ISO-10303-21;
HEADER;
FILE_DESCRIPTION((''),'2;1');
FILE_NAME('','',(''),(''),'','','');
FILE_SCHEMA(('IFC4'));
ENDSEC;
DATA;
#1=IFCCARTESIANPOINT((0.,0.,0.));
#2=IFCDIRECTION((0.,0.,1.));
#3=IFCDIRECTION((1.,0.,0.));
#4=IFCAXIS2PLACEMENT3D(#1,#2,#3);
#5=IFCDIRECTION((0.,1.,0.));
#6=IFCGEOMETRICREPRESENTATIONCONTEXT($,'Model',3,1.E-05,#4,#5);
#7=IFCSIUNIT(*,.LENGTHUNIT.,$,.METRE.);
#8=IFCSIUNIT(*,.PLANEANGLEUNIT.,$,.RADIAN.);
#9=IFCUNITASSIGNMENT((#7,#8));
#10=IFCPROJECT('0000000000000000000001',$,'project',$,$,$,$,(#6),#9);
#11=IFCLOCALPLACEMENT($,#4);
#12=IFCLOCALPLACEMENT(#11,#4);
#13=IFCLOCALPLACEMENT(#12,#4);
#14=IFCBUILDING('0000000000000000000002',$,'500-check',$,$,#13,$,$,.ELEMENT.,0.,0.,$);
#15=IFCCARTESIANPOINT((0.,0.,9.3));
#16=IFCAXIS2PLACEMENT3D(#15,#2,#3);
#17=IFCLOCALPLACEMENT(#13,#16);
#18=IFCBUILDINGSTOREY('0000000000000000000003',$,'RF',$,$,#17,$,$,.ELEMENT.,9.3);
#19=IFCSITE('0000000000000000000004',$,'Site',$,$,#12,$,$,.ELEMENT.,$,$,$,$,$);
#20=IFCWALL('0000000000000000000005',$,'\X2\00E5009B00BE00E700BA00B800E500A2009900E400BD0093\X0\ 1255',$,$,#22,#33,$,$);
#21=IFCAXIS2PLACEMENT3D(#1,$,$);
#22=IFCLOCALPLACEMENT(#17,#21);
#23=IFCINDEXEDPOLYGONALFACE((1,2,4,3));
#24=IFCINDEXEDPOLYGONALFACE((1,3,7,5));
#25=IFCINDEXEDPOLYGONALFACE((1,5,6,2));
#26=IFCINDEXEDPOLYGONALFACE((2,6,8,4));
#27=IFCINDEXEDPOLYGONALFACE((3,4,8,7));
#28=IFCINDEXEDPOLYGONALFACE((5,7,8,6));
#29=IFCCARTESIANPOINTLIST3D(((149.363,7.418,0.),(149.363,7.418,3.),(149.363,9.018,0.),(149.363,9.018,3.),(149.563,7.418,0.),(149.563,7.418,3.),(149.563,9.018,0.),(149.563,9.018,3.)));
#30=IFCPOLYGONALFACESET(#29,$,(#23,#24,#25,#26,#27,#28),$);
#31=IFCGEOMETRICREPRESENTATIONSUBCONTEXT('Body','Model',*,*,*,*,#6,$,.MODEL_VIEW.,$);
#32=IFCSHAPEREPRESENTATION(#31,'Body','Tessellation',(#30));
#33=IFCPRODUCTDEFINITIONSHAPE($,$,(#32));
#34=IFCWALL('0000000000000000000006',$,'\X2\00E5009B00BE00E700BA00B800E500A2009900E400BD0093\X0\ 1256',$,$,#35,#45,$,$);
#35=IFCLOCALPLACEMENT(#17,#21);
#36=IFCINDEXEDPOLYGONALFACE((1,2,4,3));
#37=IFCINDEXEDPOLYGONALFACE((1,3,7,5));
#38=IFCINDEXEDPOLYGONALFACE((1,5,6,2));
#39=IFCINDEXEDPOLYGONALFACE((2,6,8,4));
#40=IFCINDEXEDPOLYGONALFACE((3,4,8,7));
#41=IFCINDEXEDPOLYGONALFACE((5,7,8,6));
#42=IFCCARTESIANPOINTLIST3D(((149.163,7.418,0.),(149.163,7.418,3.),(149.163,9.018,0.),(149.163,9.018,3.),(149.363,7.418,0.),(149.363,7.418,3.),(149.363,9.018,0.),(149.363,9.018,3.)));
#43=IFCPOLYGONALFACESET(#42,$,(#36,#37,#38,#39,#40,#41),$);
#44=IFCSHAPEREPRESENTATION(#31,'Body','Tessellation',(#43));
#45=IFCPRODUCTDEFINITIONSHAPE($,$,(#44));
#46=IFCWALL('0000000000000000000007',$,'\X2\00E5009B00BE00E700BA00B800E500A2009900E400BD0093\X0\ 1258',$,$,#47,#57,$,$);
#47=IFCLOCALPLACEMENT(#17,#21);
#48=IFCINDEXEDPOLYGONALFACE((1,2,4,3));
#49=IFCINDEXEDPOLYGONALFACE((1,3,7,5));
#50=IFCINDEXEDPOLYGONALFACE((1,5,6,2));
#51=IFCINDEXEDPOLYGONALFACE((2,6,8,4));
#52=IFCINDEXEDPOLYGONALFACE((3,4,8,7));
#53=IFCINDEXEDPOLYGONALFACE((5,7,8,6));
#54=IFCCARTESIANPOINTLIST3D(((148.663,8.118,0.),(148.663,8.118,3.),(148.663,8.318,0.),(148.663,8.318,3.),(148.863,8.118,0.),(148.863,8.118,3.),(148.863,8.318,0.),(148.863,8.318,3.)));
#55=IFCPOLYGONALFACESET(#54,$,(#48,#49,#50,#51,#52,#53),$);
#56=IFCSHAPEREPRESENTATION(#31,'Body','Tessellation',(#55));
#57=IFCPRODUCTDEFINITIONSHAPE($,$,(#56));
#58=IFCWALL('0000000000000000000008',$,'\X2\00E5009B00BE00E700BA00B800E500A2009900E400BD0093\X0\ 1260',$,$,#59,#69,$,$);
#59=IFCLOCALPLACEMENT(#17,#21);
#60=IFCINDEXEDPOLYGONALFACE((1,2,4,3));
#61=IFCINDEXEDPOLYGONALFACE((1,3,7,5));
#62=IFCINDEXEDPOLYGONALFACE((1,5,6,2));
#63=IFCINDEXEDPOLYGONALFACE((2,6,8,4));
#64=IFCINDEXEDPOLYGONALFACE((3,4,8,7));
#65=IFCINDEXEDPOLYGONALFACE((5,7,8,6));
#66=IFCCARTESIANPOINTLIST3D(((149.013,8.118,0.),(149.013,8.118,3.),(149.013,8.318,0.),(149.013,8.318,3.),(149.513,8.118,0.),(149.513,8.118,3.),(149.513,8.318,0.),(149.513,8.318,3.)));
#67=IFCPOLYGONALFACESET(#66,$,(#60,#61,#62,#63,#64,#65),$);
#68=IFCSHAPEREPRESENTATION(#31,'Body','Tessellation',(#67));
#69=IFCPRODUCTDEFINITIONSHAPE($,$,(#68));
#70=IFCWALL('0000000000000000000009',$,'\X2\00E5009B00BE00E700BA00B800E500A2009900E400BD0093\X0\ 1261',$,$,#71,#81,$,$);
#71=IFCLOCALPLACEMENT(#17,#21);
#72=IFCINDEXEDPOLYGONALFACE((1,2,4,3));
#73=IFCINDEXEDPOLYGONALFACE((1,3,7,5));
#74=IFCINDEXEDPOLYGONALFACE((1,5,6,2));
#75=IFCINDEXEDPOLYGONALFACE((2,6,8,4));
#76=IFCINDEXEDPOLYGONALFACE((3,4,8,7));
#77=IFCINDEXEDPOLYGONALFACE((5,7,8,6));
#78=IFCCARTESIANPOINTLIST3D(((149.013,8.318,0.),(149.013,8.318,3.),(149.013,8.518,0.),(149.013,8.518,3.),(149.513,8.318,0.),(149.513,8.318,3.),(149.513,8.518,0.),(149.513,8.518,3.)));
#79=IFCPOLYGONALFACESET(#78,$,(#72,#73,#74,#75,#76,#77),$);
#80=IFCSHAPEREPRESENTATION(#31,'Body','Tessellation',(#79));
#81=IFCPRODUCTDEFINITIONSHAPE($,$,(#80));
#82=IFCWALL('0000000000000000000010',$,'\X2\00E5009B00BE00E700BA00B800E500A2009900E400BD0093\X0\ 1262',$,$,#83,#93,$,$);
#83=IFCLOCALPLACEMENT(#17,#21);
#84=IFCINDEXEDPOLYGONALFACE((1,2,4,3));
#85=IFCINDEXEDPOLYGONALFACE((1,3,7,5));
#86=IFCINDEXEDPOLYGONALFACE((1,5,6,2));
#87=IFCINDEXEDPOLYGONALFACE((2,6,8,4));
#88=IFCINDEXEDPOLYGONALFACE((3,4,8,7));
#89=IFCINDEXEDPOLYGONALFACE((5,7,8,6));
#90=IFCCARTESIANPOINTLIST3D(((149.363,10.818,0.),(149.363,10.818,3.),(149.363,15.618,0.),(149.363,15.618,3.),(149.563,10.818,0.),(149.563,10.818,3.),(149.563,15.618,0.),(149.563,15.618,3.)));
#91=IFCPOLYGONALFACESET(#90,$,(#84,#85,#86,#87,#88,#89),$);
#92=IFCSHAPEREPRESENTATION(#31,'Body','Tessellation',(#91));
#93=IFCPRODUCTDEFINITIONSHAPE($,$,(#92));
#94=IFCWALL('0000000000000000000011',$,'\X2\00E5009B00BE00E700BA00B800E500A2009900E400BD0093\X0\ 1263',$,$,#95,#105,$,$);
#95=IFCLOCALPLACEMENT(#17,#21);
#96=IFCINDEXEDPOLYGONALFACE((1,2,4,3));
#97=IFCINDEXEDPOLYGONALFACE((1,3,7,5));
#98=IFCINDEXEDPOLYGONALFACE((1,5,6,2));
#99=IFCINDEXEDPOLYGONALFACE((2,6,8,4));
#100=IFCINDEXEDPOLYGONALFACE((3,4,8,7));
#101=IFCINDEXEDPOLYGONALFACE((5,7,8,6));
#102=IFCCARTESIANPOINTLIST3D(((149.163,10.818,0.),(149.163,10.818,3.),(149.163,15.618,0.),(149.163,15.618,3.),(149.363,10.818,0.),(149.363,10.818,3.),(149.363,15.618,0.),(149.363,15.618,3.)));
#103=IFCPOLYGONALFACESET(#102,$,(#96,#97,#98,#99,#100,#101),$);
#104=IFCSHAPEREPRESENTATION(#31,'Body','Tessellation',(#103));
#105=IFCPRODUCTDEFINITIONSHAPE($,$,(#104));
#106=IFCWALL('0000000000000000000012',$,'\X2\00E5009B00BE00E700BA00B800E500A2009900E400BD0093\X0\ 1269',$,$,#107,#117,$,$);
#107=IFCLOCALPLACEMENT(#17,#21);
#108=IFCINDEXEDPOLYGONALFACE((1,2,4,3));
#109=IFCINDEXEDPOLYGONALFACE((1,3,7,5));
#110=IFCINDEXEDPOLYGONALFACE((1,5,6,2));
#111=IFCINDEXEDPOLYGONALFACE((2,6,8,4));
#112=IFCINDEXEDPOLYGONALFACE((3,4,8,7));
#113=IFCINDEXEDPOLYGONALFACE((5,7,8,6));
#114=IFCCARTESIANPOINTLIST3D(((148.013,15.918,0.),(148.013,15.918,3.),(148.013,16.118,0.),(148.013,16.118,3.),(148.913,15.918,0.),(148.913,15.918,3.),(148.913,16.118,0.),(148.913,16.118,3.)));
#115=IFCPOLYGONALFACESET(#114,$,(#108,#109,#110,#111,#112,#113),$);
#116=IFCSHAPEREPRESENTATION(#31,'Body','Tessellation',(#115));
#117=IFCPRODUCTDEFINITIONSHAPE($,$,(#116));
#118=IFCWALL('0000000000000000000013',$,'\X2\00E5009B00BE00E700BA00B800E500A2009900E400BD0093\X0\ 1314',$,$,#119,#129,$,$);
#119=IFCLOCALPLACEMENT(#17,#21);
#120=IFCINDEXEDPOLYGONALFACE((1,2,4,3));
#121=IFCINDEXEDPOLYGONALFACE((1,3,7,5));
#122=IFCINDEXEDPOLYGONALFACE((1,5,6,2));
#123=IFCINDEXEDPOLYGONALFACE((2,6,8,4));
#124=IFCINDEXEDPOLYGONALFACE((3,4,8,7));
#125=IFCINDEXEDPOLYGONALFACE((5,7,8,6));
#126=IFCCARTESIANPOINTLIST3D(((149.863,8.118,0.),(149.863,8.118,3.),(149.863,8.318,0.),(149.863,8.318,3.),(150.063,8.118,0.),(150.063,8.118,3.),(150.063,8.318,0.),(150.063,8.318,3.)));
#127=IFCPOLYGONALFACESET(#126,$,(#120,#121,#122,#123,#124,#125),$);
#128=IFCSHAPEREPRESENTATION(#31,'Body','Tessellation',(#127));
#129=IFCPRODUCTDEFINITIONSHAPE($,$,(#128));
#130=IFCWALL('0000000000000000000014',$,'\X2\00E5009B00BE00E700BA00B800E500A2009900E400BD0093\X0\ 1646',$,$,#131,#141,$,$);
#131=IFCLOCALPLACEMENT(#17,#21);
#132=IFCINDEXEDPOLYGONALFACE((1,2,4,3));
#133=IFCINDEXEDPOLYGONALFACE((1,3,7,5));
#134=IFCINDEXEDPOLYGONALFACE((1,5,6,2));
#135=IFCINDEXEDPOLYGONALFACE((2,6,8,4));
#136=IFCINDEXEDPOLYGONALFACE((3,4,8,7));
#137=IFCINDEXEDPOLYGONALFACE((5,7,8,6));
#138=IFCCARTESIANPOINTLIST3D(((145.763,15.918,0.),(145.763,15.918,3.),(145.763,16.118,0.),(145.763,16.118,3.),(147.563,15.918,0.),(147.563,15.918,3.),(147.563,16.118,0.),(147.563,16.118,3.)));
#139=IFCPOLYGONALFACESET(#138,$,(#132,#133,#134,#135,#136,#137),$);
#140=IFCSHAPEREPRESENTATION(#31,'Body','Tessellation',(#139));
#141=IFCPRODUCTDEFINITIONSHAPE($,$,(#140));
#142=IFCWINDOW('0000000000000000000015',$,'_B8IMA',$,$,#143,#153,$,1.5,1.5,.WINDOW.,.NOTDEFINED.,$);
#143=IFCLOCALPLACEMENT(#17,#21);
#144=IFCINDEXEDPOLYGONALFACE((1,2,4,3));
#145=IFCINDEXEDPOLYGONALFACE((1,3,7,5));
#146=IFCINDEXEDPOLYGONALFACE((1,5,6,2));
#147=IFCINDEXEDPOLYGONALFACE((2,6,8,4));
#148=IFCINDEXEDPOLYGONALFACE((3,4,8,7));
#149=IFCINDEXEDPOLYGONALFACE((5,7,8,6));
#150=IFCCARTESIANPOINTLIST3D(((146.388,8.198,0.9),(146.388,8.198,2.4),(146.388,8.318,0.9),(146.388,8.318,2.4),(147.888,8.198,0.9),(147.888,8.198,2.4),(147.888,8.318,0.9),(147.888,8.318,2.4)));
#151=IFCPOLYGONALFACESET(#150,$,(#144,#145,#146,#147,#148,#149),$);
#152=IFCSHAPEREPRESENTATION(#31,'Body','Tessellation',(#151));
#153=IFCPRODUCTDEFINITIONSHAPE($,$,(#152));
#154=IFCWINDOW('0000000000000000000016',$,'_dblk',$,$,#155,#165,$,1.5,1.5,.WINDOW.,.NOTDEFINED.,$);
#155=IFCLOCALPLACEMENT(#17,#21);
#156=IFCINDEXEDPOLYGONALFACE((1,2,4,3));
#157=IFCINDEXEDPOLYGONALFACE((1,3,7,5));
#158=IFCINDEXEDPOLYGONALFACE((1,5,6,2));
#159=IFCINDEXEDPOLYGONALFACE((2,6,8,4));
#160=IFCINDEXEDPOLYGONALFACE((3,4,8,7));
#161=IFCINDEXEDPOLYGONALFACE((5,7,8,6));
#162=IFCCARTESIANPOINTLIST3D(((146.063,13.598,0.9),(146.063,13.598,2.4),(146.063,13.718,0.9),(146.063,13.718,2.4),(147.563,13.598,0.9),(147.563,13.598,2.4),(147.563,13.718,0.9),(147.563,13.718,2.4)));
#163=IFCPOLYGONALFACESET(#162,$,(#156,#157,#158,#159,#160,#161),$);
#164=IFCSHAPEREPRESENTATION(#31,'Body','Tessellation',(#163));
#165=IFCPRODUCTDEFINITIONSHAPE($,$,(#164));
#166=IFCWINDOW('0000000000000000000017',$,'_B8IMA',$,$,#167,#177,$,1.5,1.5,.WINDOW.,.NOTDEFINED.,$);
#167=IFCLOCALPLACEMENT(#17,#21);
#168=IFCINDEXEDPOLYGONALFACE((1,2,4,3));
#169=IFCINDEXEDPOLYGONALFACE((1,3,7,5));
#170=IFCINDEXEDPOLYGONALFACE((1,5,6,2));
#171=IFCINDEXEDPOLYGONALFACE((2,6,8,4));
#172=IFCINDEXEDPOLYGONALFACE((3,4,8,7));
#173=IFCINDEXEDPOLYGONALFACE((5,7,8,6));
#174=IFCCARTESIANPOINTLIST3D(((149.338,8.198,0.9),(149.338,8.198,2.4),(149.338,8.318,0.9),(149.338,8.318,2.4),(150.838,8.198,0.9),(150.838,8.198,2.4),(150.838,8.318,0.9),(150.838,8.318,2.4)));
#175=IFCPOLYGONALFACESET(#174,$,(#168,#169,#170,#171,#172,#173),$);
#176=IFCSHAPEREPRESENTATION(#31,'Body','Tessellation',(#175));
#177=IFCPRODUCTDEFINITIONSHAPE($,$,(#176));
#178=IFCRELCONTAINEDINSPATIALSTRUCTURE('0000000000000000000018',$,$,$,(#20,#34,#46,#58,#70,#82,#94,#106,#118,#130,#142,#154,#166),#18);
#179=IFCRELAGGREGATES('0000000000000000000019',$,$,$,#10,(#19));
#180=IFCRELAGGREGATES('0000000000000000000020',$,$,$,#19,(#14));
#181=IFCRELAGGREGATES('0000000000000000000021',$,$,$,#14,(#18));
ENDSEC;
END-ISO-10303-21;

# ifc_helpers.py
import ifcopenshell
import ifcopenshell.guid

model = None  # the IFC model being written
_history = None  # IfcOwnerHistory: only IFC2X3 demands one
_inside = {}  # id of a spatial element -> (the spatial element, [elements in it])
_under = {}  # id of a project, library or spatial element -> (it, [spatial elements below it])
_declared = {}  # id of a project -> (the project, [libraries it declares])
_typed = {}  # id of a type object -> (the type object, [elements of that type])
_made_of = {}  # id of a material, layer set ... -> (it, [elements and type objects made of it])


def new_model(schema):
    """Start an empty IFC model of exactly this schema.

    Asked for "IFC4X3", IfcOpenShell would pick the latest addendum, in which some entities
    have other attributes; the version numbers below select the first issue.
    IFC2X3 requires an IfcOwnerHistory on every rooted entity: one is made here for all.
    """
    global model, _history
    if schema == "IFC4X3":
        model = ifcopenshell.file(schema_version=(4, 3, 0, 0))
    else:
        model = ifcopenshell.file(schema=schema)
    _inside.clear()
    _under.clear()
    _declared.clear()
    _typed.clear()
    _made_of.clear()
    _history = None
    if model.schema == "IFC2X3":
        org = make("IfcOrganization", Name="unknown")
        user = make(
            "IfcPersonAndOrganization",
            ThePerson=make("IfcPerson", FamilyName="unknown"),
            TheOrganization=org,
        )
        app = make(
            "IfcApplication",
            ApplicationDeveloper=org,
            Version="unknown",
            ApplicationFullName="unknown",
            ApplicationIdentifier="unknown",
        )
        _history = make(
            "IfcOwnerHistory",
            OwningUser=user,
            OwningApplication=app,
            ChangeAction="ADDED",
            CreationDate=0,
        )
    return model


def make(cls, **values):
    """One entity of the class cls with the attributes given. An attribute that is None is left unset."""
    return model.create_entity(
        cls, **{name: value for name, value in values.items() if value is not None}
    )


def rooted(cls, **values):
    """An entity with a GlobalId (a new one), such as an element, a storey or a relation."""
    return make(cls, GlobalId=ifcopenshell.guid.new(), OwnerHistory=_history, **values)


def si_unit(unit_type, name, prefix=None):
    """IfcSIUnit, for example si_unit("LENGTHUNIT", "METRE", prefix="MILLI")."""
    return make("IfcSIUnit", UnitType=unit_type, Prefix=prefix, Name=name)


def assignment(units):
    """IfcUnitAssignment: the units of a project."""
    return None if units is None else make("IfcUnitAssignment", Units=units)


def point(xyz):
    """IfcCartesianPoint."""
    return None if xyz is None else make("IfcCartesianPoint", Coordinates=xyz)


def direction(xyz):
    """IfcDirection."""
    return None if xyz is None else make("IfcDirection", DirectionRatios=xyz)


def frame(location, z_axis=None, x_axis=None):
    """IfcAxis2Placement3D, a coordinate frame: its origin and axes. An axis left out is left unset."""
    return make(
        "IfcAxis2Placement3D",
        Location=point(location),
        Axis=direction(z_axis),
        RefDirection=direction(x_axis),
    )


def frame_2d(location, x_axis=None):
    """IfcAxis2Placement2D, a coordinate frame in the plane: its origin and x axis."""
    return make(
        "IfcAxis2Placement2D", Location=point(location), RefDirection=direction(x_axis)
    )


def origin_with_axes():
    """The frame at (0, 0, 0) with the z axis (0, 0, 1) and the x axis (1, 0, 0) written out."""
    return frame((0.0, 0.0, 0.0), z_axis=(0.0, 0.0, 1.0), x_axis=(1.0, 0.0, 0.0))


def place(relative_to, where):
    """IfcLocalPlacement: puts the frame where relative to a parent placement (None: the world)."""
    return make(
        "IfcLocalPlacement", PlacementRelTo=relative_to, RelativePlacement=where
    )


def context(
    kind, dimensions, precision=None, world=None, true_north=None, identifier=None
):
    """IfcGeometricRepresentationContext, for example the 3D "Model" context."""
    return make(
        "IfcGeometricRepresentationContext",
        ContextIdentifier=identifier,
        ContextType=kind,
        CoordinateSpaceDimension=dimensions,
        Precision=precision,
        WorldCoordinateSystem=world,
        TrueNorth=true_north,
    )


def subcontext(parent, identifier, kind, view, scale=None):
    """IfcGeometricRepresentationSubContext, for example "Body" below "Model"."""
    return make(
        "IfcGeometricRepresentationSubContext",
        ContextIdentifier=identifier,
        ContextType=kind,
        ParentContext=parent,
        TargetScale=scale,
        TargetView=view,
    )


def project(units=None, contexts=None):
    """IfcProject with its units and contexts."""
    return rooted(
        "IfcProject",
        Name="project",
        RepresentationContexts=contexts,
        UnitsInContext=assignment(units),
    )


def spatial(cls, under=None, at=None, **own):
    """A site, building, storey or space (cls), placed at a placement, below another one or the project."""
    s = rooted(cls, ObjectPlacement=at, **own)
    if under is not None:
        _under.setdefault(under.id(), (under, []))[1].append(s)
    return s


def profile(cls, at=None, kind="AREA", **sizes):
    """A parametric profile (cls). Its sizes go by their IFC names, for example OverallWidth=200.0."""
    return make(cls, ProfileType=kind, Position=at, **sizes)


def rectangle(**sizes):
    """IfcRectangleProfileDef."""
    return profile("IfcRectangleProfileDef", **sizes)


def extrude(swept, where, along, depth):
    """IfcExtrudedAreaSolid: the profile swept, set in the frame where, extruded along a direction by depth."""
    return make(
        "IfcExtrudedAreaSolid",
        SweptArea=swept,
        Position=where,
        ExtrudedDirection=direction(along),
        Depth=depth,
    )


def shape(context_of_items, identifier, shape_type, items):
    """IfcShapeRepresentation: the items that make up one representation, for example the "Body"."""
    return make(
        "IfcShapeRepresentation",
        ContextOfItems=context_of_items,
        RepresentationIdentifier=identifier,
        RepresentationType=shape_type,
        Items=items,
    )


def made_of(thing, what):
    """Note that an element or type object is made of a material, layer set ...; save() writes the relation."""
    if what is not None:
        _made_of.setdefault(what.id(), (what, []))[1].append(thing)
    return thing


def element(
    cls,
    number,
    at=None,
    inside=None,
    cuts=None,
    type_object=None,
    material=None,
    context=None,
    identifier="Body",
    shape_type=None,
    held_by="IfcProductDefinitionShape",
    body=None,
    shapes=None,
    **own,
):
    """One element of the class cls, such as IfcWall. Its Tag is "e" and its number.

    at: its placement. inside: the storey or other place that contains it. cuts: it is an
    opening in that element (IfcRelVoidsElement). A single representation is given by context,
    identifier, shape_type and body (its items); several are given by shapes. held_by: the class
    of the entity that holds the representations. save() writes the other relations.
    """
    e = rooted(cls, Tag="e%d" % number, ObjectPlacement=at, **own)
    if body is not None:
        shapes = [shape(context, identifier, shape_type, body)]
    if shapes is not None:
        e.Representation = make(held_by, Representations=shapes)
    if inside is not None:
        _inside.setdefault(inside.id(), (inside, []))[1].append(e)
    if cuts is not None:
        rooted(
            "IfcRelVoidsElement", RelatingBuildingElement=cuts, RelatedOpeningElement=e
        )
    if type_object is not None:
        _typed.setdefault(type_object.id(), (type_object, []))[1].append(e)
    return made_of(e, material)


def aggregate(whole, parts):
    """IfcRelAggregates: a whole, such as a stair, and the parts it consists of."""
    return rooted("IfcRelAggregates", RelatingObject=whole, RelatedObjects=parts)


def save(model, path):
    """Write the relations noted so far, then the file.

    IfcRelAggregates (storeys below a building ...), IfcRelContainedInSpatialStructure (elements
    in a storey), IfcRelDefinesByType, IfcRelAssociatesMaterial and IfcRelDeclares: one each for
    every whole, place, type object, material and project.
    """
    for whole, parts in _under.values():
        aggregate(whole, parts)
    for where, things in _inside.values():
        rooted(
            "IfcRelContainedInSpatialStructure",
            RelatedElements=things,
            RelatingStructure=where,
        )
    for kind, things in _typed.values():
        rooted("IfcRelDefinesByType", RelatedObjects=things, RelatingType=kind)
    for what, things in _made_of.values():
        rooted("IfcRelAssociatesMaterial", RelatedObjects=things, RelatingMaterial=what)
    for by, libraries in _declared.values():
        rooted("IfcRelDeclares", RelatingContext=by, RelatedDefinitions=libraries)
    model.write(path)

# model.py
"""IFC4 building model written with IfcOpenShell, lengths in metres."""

from ifc_helpers import new_model, si_unit, direction, frame, frame_2d, origin_with_axes, place, context, subcontext, project, spatial, rectangle, extrude, element, save


model = new_model("IFC4")

# Units and contexts
model_context = context("Model", 3, precision=1e-05, world=origin_with_axes(), true_north=direction((0.0, 1.0, 0.0)))
body_context = subcontext(model_context, "Body", "Model", "MODEL_VIEW")
ifc_project = project(units=[si_unit("LENGTHUNIT", "METRE"), si_unit("PLANEANGLEUNIT", "RADIAN")], contexts=[model_context])

# Site, building, storey
placement = place(None, origin_with_axes())
site_placement = place(placement, origin_with_axes())
site = spatial("IfcSite", under=ifc_project, at=site_placement, Name="Site", CompositionType="ELEMENT")
building_placement = place(site_placement, origin_with_axes())
building = spatial("IfcBuilding", under=site, at=building_placement, Name="500-check", CompositionType="ELEMENT", ElevationOfRefHeight=0.0, ElevationOfTerrain=0.0)
storey_placement = place(building_placement, frame((0.0, 0.0, 9.3), z_axis=(0.0, 0.0, 1.0), x_axis=(1.0, 0.0, 0.0)))
storey = spatial("IfcBuildingStorey", under=building, at=storey_placement, Name="RF", CompositionType="ELEMENT", Elevation=9.3)

# Walls
for number, where, z_axis, x_axis, name in (
    (1, (149.463, 8.218, 0.0), (0.0, 0.0, 1.0), (0.0, -1.0, 0.0), "å\u009b¾çº¸å¢\u0099ä½\u0093 1255"),
    (2, (149.263, 8.218, 0.0), (0.0, 0.0, 1.0), (0.0, -1.0, 0.0), "å\u009b¾çº¸å¢\u0099ä½\u0093 1256"),
):
    element("IfcWall", number, at=place(storey_placement, frame(where, z_axis=z_axis, x_axis=x_axis)), inside=storey, Name=name, context=body_context, shape_type="SweptSolid", body=[
        extrude(rectangle(XDim=1.6, YDim=0.2, at=frame_2d((0.0, 0.0), x_axis=(1.0, 0.0, 0.0))), frame((0.0, 0.0, 0.0), z_axis=(0.0, 0.0, 1.0)), (0.0, 0.0, 1.0), 3.0),
    ])
wall_1_placement = place(storey_placement, frame((148.763, 8.218, 0.0), z_axis=(0.0, 0.0, 1.0), x_axis=(0.0, 1.0, 0.0)))
element("IfcWall", 3, at=wall_1_placement, inside=storey, Name="å\u009b¾çº¸å¢\u0099ä½\u0093 1258", context=body_context, shape_type="SweptSolid", body=[
    extrude(rectangle(XDim=0.2, YDim=0.2, at=frame_2d((0.0, 0.0), x_axis=(1.0, 0.0, 0.0))), frame((0.0, 0.0, 0.0), z_axis=(0.0, 0.0, 1.0)), (0.0, 0.0, 1.0), 3.0),
])
for number, where, z_axis, x_axis, name in (
    (4, (149.263, 8.218, 0.0), (0.0, 0.0, 1.0), (-1.0, 0.0, 0.0), "å\u009b¾çº¸å¢\u0099ä½\u0093 1260"),
    (5, (149.263, 8.418, 0.0), (0.0, 0.0, 1.0), (-1.0, 0.0, 0.0), "å\u009b¾çº¸å¢\u0099ä½\u0093 1261"),
):
    element("IfcWall", number, at=place(storey_placement, frame(where, z_axis=z_axis, x_axis=x_axis)), inside=storey, Name=name, context=body_context, shape_type="SweptSolid", body=[
        extrude(rectangle(XDim=0.5, YDim=0.2, at=frame_2d((0.0, 0.0), x_axis=(1.0, 0.0, 0.0))), frame((0.0, 0.0, 0.0), z_axis=(0.0, 0.0, 1.0)), (0.0, 0.0, 1.0), 3.0),
    ])
for number, where, z_axis, x_axis, name in (
    (6, (149.463, 13.218, 0.0), (0.0, 0.0, 1.0), (0.0, -1.0, 0.0), "å\u009b¾çº¸å¢\u0099ä½\u0093 1262"),
    (7, (149.263, 13.218, 0.0), (0.0, 0.0, 1.0), (0.0, -1.0, 0.0), "å\u009b¾çº¸å¢\u0099ä½\u0093 1263"),
):
    element("IfcWall", number, at=place(storey_placement, frame(where, z_axis=z_axis, x_axis=x_axis)), inside=storey, Name=name, context=body_context, shape_type="SweptSolid", body=[
        extrude(rectangle(XDim=4.8, YDim=0.2, at=frame_2d((0.0, 0.0), x_axis=(1.0, 0.0, 0.0))), frame((0.0, 0.0, 0.0), z_axis=(0.0, 0.0, 1.0)), (0.0, 0.0, 1.0), 3.0),
    ])
wall_2_placement = place(storey_placement, frame((148.463, 16.018, 0.0), z_axis=(0.0, 0.0, 1.0), x_axis=(1.0, 0.0, 0.0)))
element("IfcWall", 8, at=wall_2_placement, inside=storey, Name="å\u009b¾çº¸å¢\u0099ä½\u0093 1269", context=body_context, shape_type="SweptSolid", body=[
    extrude(rectangle(XDim=0.9, YDim=0.2, at=frame_2d((0.0, 0.0), x_axis=(1.0, 0.0, 0.0))), frame((0.0, 0.0, 0.0), z_axis=(0.0, 0.0, 1.0)), (0.0, 0.0, 1.0), 3.0),
])
wall_3_placement = place(storey_placement, frame((149.963, 8.218, 0.0), z_axis=(0.0, 0.0, 1.0), x_axis=(0.0, 1.0, 0.0)))
element("IfcWall", 9, at=wall_3_placement, inside=storey, Name="å\u009b¾çº¸å¢\u0099ä½\u0093 1314", context=body_context, shape_type="SweptSolid", body=[
    extrude(rectangle(XDim=0.2, YDim=0.2, at=frame_2d((0.0, 0.0), x_axis=(1.0, 0.0, 0.0))), frame((0.0, 0.0, 0.0), z_axis=(0.0, 0.0, 1.0)), (0.0, 0.0, 1.0), 3.0),
])
wall_4_placement = place(storey_placement, frame((146.663, 16.018, 0.0), z_axis=(0.0, 0.0, 1.0), x_axis=(1.0, 0.0, 0.0)))
element("IfcWall", 10, at=wall_4_placement, inside=storey, Name="å\u009b¾çº¸å¢\u0099ä½\u0093 1646", context=body_context, shape_type="SweptSolid", body=[
    extrude(rectangle(XDim=1.8, YDim=0.2, at=frame_2d((0.0, 0.0), x_axis=(1.0, 0.0, 0.0))), frame((0.0, 0.0, 0.0), z_axis=(0.0, 0.0, 1.0)), (0.0, 0.0, 1.0), 3.0),
])

# Windows
for number, where, z_axis, x_axis, name in (
    (11, (147.138, 8.258, 0.9), (0.0, 0.0, 1.0), (1.0, 0.0, 0.0), "_B8IMA"),
    (12, (146.813, 13.658, 0.9), (0.0, 0.0, 1.0), (1.0, 0.0, 0.0), "_dblk"),
    (13, (150.088, 8.258, 0.9), (0.0, 0.0, 1.0), (1.0, 0.0, 0.0), "_B8IMA"),
):
    element("IfcWindow", number, at=place(storey_placement, frame(where, z_axis=z_axis, x_axis=x_axis)), inside=storey, Name=name, OverallHeight=1.5, OverallWidth=1.5, PartitioningType="NOTDEFINED", PredefinedType="WINDOW", context=body_context, shape_type="SweptSolid", body=[
        extrude(rectangle(XDim=1.5, YDim=0.12, at=frame_2d((0.0, 0.0), x_axis=(1.0, 0.0, 0.0))), frame((0.0, 0.0, 0.0), z_axis=(0.0, 0.0, 1.0)), (0.0, 0.0, 1.0), 1.5),
    ])

save(model, "model.ifc")
